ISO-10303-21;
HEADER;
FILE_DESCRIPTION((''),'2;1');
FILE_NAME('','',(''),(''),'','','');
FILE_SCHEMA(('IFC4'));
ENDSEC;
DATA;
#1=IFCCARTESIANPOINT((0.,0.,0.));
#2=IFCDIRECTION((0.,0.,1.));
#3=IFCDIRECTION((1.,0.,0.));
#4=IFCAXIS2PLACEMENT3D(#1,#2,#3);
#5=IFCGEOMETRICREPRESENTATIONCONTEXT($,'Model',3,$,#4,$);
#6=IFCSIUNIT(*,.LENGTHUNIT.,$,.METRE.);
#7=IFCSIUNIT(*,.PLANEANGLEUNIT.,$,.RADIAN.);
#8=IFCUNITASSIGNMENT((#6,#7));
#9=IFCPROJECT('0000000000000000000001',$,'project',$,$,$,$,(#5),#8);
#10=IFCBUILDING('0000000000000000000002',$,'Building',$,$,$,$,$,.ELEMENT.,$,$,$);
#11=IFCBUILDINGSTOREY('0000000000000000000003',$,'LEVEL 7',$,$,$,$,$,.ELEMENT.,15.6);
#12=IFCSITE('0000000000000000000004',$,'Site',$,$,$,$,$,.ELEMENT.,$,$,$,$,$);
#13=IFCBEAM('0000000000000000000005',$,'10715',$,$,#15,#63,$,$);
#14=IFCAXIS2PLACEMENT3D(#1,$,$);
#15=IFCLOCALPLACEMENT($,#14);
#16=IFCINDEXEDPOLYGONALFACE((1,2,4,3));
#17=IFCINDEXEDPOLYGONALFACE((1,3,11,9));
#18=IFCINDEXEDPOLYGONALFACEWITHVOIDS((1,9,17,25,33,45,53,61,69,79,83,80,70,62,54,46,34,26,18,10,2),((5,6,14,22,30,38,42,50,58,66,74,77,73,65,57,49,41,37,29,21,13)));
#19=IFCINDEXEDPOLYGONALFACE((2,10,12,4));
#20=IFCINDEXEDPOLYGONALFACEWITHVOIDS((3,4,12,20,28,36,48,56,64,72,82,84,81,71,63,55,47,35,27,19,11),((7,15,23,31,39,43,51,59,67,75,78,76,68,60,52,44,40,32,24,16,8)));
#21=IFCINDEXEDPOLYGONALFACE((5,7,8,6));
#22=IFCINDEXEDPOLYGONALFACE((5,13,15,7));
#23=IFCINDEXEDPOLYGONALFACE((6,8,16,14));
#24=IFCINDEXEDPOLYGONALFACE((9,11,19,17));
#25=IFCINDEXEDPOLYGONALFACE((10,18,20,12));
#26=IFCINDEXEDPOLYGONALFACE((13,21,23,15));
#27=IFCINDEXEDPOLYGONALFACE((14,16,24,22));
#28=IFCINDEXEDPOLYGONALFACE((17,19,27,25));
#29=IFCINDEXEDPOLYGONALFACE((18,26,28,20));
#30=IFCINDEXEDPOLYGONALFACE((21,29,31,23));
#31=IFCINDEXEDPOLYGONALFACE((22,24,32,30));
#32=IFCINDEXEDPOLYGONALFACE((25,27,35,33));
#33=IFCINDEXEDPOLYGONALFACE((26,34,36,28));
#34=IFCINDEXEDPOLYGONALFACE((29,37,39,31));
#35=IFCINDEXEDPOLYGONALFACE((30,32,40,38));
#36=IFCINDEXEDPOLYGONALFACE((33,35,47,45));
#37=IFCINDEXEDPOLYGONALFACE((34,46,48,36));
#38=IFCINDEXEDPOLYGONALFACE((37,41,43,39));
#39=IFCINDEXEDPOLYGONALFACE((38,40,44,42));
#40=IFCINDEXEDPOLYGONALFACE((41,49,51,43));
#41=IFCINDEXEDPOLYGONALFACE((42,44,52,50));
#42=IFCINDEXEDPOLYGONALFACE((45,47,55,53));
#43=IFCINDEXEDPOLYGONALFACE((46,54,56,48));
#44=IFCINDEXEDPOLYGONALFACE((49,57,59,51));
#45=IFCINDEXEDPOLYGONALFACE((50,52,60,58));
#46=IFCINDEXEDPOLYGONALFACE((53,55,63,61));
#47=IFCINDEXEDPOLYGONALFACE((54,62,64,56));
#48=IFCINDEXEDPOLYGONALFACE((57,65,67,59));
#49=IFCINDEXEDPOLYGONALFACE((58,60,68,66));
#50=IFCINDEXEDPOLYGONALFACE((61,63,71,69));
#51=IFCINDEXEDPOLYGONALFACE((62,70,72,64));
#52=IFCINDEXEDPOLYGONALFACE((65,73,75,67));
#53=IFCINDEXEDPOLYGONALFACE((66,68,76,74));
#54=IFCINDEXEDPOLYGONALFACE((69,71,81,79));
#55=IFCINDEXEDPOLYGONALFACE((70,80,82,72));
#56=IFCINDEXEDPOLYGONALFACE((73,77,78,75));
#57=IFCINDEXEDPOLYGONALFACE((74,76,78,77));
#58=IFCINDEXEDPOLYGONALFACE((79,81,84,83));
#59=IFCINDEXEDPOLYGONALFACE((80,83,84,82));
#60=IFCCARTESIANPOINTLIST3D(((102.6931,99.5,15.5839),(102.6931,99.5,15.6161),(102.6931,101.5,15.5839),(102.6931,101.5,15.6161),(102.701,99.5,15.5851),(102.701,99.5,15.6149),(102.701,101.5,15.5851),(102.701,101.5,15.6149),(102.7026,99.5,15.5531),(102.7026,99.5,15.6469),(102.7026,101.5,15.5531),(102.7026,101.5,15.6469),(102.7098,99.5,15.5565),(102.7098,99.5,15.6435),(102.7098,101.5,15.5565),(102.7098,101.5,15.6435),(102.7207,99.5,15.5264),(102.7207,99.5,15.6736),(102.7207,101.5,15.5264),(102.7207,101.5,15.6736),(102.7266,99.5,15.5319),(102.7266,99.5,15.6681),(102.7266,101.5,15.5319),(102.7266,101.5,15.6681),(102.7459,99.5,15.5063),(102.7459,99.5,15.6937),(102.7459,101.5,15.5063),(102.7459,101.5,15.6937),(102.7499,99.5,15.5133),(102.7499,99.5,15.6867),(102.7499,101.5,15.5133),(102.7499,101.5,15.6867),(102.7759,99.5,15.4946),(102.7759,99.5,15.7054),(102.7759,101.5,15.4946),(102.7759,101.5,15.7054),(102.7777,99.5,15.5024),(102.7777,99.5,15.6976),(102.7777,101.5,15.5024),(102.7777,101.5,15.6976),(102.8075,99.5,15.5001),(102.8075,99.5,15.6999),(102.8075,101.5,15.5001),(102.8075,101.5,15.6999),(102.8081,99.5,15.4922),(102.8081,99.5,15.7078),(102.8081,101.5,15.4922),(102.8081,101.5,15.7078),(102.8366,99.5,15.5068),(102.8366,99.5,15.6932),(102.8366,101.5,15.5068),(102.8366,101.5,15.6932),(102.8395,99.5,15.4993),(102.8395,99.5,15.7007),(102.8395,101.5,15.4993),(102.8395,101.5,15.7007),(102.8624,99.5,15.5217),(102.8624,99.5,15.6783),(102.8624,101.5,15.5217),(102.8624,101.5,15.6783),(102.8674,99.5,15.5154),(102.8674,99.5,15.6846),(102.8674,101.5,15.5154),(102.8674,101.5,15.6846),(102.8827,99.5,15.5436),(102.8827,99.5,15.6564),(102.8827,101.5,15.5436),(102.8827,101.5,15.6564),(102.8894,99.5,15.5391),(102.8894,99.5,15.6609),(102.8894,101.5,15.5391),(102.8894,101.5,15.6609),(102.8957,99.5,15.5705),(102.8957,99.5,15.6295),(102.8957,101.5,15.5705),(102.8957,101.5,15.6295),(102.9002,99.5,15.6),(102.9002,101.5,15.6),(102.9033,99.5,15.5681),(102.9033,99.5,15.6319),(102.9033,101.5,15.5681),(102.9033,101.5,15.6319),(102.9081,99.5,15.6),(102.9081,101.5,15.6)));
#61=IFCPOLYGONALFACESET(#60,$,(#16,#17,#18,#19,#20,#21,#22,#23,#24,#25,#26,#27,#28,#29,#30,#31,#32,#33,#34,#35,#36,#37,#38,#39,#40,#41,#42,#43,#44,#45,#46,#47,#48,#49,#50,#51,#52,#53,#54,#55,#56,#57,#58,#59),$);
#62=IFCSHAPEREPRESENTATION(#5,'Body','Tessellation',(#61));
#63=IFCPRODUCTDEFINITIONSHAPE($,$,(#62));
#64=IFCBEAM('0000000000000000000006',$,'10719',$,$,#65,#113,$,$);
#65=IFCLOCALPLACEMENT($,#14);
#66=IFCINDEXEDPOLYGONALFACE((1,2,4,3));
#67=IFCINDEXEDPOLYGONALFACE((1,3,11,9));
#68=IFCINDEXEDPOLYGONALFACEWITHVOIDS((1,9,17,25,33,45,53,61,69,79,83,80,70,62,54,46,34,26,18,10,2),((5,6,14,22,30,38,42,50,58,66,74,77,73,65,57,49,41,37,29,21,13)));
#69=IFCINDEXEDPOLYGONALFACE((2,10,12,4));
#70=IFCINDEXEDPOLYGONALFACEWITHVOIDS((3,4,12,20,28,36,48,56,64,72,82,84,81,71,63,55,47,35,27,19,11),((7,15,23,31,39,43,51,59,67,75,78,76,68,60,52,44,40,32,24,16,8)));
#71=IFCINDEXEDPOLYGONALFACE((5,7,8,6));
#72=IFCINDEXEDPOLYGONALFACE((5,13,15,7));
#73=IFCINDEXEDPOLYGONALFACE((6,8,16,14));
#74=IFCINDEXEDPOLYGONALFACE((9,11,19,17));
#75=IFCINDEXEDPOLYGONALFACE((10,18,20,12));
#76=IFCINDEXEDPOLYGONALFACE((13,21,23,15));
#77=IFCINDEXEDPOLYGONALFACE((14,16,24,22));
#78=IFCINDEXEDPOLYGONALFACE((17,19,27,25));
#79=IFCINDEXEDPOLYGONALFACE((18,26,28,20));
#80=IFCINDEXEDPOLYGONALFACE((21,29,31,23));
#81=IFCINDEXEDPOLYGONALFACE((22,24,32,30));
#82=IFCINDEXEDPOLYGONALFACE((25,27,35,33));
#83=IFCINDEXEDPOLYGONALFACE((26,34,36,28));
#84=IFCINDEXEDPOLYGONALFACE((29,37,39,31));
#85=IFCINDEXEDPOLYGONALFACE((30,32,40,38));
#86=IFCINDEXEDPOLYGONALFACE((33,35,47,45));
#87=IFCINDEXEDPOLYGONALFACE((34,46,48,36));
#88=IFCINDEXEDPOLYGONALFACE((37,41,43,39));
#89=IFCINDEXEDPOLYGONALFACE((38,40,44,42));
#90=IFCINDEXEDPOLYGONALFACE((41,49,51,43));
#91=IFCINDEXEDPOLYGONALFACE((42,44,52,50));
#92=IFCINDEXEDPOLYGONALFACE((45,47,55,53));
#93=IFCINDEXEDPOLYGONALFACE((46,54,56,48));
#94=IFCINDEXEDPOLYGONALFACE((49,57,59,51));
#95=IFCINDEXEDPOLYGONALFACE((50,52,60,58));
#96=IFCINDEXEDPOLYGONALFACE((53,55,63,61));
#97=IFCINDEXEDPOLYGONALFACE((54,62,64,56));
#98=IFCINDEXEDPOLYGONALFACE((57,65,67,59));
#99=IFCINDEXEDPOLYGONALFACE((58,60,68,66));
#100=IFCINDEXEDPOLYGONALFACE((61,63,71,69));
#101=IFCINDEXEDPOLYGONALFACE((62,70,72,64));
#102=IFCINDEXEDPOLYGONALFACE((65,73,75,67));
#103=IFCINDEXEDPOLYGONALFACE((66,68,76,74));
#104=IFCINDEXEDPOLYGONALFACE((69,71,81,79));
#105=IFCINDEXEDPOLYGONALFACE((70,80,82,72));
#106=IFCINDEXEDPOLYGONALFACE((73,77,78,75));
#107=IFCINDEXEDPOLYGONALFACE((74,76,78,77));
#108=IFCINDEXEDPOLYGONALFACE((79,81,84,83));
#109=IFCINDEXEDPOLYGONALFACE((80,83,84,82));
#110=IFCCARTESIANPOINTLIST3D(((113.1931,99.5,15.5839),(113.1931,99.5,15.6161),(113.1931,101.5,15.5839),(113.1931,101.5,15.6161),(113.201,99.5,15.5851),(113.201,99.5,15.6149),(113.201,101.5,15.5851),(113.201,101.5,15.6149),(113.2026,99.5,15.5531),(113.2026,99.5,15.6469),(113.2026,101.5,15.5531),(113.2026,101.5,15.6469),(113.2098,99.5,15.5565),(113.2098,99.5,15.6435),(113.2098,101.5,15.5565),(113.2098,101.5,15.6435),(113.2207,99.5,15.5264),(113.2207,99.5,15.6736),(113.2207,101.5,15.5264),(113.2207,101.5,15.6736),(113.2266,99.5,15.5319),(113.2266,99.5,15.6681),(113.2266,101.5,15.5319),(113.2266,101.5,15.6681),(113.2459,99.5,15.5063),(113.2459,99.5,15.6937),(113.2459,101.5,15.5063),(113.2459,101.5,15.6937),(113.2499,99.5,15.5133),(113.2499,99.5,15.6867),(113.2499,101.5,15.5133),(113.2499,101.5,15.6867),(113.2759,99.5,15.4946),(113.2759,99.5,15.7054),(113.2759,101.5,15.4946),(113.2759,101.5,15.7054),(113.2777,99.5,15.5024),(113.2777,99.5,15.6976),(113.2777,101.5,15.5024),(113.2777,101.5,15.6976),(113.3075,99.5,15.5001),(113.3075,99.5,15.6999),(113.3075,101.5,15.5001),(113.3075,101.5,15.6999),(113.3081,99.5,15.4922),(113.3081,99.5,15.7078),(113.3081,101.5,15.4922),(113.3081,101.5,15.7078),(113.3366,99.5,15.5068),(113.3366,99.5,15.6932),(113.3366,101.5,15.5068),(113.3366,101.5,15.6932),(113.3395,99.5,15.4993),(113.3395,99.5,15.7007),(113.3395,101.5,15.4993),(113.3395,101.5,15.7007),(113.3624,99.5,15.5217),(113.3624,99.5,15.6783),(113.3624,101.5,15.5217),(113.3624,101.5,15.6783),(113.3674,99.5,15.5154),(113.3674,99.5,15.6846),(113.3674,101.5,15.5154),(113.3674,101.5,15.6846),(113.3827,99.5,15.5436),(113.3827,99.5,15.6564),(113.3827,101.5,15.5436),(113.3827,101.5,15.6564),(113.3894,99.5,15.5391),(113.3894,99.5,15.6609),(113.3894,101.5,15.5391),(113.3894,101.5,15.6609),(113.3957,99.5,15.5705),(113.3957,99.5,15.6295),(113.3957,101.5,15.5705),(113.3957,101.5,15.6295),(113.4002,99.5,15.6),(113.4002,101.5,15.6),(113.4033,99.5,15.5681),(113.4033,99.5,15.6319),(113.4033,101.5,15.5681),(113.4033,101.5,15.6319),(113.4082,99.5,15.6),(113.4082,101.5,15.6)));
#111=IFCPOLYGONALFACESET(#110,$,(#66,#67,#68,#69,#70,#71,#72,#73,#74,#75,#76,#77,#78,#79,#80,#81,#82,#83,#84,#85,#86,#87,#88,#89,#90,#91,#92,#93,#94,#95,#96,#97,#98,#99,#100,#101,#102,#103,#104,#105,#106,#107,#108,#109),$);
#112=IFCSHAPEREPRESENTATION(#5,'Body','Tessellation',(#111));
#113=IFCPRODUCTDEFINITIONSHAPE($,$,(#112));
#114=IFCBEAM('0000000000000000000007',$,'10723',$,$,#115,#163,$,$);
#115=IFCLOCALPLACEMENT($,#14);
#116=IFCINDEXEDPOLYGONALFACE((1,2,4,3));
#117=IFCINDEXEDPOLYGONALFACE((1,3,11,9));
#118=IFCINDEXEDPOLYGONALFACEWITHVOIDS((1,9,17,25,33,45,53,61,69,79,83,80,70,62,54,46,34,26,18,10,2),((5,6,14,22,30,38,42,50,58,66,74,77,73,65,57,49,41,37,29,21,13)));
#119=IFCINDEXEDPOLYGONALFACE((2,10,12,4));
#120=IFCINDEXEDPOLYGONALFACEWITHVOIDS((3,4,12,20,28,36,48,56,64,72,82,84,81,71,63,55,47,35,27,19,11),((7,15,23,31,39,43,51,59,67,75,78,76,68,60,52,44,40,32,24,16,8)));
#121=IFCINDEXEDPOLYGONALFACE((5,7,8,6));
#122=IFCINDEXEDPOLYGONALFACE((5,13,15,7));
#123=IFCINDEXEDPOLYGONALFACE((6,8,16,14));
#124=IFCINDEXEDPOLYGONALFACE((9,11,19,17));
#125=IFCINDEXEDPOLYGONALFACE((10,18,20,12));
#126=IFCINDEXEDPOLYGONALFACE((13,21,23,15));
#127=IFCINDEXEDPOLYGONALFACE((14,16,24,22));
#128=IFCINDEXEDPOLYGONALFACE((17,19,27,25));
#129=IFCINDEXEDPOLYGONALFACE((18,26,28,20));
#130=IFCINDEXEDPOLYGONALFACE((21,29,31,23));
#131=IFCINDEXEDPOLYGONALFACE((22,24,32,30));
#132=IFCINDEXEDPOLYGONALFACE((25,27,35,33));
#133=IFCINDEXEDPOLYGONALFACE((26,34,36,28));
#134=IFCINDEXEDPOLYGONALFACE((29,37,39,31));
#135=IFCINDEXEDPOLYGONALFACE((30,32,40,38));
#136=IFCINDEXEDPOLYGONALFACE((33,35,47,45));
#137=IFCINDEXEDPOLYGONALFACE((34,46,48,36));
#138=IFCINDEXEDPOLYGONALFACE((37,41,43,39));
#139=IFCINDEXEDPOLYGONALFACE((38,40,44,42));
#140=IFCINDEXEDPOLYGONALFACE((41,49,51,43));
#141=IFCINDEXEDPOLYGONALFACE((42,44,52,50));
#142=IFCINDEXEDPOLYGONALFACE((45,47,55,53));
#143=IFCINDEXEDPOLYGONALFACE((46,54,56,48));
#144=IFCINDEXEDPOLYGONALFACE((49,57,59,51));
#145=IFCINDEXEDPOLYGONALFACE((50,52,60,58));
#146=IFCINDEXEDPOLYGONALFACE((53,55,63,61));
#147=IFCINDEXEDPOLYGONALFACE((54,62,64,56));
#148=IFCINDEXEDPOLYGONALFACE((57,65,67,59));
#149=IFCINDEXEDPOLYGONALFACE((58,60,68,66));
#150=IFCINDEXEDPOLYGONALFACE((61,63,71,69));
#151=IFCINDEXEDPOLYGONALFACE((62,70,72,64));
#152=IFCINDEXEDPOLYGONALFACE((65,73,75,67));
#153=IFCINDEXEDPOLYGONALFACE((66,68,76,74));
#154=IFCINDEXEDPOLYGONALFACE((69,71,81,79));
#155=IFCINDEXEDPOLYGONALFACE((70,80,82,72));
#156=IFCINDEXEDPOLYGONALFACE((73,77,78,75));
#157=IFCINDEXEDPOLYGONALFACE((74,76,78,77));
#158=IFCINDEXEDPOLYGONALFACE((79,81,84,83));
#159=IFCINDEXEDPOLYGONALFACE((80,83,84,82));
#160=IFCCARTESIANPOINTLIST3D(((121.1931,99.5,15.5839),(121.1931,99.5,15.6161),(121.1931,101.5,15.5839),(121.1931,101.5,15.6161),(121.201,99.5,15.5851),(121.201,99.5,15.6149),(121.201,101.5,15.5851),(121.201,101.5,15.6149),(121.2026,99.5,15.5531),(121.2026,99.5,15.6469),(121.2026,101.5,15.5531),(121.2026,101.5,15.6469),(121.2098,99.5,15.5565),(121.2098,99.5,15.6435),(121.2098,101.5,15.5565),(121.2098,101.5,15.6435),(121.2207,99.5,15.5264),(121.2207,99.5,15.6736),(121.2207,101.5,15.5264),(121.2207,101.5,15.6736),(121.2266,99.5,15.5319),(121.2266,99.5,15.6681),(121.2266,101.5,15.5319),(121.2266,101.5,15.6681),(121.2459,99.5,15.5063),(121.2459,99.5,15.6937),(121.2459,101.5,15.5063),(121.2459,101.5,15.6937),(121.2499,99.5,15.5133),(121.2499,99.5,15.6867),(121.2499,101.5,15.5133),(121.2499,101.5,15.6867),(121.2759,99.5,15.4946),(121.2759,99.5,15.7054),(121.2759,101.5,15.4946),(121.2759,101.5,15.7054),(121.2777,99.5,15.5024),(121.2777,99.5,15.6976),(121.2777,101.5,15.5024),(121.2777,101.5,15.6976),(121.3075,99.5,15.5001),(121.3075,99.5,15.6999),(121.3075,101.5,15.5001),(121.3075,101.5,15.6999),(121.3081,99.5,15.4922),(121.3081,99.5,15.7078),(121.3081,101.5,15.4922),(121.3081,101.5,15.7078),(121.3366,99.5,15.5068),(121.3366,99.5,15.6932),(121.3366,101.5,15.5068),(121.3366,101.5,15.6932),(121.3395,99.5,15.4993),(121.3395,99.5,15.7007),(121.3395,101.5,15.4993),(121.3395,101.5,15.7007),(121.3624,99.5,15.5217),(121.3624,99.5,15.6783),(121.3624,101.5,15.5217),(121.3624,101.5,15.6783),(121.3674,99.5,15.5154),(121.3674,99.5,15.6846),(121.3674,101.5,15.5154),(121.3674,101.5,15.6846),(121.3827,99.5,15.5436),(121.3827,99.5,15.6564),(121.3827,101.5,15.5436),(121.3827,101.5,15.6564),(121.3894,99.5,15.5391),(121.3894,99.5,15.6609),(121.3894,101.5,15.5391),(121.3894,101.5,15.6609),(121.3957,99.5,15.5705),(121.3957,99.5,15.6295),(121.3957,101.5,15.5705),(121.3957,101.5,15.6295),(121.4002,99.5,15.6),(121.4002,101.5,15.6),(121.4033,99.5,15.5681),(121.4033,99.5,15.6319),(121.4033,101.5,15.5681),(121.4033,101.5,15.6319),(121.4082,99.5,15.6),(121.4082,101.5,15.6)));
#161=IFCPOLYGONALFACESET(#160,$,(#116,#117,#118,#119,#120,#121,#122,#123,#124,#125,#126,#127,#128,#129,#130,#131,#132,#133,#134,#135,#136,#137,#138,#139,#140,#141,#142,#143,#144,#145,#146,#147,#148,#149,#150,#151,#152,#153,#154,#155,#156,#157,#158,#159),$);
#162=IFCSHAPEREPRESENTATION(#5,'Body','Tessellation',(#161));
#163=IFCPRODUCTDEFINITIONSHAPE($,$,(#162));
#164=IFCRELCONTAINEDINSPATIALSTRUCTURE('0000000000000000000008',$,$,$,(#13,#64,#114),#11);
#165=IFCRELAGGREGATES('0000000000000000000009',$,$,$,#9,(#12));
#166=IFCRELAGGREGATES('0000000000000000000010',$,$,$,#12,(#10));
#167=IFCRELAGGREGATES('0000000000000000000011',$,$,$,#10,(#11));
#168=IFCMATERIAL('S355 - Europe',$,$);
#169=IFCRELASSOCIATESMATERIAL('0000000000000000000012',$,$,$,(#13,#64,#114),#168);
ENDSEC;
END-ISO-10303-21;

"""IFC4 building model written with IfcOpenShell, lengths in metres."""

from ifc_helpers import new_model, si_unit, frame, origin_with_axes, origin_2d_with_axis, place, context, project, spatial, hollow_circle, extrude, material, material_profile, profile_set, profile_usage, element, save


model = new_model("IFC4")

# Units and contexts
model_context = context("Model", 3, world=origin_with_axes())
ifc_project = project(units=[si_unit("LENGTHUNIT", "METRE"), si_unit("PLANEANGLEUNIT", "RADIAN")], contexts=[model_context])

# Site, building, storey
site = spatial("IfcSite", under=ifc_project, Name="Site", CompositionType="ELEMENT")
building = spatial("IfcBuilding", under=site, Name="Building", CompositionType="ELEMENT")
storey = spatial("IfcBuildingStorey", under=building, Name="LEVEL 7", CompositionType="ELEMENT", Elevation=15.6)

# Shared definitions
ifc_material = material(Name="S355 - Europe")

# Beams
ifc_material_profile_1 = material_profile(ifc_material, hollow_circle(Radius=0.1081, WallThickness=0.008, at=origin_2d_with_axis()))
ifc_profile_set_1 = profile_set([ifc_material_profile_1])
ifc_profile_usage_1 = profile_usage(ifc_profile_set_1, cardinal=10)
beam_1_placement = place(None, frame((102.8, 101.5, 15.6), z_axis=(0.0, -1.0, 0.0), x_axis=(1.0, 0.0, 0.0)))
element("IfcBeam", 1, at=beam_1_placement, inside=storey, material=ifc_profile_usage_1, Name="10715", context=model_context, shape_type="SweptSolid", body=[
    extrude(hollow_circle(Radius=0.1081, WallThickness=0.008, at=origin_2d_with_axis()), origin_with_axes(), (0.0, 0.0, 1.0), 2.0),
])
ifc_material_profile_2 = material_profile(ifc_material, hollow_circle(Radius=0.1081, WallThickness=0.008, at=origin_2d_with_axis()))
ifc_profile_set_2 = profile_set([ifc_material_profile_2])
ifc_profile_usage_2 = profile_usage(ifc_profile_set_2, cardinal=10)
beam_2_placement = place(None, frame((113.3, 101.5, 15.6), z_axis=(0.0, -1.0, 0.0), x_axis=(1.0, 0.0, 0.0)))
element("IfcBeam", 2, at=beam_2_placement, inside=storey, material=ifc_profile_usage_2, Name="10719", context=model_context, shape_type="SweptSolid", body=[
    extrude(hollow_circle(Radius=0.1081, WallThickness=0.008, at=origin_2d_with_axis()), origin_with_axes(), (0.0, 0.0, 1.0), 2.0),
])
ifc_material_profile_3 = material_profile(ifc_material, hollow_circle(Radius=0.1081, WallThickness=0.008, at=origin_2d_with_axis()))
ifc_profile_set_3 = profile_set([ifc_material_profile_3])
ifc_profile_usage_3 = profile_usage(ifc_profile_set_3, cardinal=10)
beam_3_placement = place(None, frame((121.3, 101.5, 15.6), z_axis=(0.0, -1.0, 0.0), x_axis=(1.0, 0.0, 0.0)))
element("IfcBeam", 3, at=beam_3_placement, inside=storey, material=ifc_profile_usage_3, Name="10723", context=model_context, shape_type="SweptSolid", body=[
    extrude(hollow_circle(Radius=0.1081, WallThickness=0.008, at=origin_2d_with_axis()), origin_with_axes(), (0.0, 0.0, 1.0), 2.0),
])

save(model, "model.ifc")
